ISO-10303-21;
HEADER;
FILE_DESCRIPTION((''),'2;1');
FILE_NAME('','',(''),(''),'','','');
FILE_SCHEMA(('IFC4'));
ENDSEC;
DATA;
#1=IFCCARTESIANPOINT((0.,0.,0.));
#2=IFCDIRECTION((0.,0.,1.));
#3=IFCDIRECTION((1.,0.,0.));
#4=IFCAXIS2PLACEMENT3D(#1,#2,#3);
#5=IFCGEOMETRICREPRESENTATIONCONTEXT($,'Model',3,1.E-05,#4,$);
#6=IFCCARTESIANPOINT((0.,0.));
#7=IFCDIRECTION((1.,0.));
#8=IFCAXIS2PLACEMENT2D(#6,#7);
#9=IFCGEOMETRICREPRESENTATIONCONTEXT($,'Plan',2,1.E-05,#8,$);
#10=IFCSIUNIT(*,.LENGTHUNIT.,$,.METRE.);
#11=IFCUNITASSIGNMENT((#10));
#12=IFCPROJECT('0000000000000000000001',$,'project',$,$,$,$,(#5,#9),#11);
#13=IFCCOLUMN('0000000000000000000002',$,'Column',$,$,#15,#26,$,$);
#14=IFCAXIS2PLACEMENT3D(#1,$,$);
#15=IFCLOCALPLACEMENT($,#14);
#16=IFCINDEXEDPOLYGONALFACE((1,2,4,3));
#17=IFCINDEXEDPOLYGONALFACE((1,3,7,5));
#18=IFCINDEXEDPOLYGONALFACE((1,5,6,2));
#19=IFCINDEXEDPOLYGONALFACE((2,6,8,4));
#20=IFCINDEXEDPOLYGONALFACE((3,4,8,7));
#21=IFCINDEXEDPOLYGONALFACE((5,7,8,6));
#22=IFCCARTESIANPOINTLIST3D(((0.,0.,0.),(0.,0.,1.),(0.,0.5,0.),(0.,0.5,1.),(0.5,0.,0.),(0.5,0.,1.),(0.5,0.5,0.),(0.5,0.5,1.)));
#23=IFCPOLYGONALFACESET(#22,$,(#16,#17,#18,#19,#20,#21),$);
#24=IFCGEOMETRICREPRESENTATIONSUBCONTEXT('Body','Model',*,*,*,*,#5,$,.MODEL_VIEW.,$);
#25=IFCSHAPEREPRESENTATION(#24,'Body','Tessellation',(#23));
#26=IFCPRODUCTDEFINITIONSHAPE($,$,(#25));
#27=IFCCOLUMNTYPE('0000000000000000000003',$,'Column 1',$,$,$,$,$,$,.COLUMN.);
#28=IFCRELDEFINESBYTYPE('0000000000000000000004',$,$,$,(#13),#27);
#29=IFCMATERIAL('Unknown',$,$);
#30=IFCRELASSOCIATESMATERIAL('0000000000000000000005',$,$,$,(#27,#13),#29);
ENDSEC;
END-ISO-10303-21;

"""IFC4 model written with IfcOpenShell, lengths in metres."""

from ifc_helpers import new_model, si_unit, frame, origin_with_axes, origin_2d_with_axis, place, context, subcontext, project, rectangle, extrude, material, material_profile, profile_set, profile_usage, type_object, element, save


model = new_model("IFC4")

# Units and contexts
model_context = context("Model", 3, precision=1e-05, world=origin_with_axes())
plan_context = context("Plan", 2, precision=1e-05, world=origin_2d_with_axis())
body_context = subcontext(model_context, "Body", "Model", "MODEL_VIEW")
ifc_project = project(units=[si_unit("LENGTHUNIT", "METRE")], contexts=[model_context, plan_context])

# Column
ifc_material = material(Name="Unknown")
ifc_material_profile = material_profile(ifc_material, rectangle(XDim=0.5, YDim=0.5))
ifc_profile_set = profile_set([ifc_material_profile])
ifc_profile_usage = profile_usage(ifc_profile_set, cardinal=3)
column_type = type_object("IfcColumnType", Name="Column 1", PredefinedType="COLUMN", material=ifc_profile_set)
placement_1 = place(None, origin_with_axes())
placement_2 = place(placement_1, origin_with_axes())
placement_3 = place(placement_2, origin_with_axes())
column_placement = place(placement_3, origin_with_axes())
element("IfcColumn", 1, at=column_placement, type_object=column_type, material=ifc_profile_usage, Name="Column", context=body_context, shape_type="SweptSolid", body=[
    extrude(rectangle(XDim=0.5, YDim=0.5), frame((0.25, 0.25, 0.0), z_axis=(0.0, 0.0, 1.0), x_axis=(1.0, 0.0, 0.0)), (0.0, 0.0, 1.0), 1.0),
])

save(model, "model.ifc")
